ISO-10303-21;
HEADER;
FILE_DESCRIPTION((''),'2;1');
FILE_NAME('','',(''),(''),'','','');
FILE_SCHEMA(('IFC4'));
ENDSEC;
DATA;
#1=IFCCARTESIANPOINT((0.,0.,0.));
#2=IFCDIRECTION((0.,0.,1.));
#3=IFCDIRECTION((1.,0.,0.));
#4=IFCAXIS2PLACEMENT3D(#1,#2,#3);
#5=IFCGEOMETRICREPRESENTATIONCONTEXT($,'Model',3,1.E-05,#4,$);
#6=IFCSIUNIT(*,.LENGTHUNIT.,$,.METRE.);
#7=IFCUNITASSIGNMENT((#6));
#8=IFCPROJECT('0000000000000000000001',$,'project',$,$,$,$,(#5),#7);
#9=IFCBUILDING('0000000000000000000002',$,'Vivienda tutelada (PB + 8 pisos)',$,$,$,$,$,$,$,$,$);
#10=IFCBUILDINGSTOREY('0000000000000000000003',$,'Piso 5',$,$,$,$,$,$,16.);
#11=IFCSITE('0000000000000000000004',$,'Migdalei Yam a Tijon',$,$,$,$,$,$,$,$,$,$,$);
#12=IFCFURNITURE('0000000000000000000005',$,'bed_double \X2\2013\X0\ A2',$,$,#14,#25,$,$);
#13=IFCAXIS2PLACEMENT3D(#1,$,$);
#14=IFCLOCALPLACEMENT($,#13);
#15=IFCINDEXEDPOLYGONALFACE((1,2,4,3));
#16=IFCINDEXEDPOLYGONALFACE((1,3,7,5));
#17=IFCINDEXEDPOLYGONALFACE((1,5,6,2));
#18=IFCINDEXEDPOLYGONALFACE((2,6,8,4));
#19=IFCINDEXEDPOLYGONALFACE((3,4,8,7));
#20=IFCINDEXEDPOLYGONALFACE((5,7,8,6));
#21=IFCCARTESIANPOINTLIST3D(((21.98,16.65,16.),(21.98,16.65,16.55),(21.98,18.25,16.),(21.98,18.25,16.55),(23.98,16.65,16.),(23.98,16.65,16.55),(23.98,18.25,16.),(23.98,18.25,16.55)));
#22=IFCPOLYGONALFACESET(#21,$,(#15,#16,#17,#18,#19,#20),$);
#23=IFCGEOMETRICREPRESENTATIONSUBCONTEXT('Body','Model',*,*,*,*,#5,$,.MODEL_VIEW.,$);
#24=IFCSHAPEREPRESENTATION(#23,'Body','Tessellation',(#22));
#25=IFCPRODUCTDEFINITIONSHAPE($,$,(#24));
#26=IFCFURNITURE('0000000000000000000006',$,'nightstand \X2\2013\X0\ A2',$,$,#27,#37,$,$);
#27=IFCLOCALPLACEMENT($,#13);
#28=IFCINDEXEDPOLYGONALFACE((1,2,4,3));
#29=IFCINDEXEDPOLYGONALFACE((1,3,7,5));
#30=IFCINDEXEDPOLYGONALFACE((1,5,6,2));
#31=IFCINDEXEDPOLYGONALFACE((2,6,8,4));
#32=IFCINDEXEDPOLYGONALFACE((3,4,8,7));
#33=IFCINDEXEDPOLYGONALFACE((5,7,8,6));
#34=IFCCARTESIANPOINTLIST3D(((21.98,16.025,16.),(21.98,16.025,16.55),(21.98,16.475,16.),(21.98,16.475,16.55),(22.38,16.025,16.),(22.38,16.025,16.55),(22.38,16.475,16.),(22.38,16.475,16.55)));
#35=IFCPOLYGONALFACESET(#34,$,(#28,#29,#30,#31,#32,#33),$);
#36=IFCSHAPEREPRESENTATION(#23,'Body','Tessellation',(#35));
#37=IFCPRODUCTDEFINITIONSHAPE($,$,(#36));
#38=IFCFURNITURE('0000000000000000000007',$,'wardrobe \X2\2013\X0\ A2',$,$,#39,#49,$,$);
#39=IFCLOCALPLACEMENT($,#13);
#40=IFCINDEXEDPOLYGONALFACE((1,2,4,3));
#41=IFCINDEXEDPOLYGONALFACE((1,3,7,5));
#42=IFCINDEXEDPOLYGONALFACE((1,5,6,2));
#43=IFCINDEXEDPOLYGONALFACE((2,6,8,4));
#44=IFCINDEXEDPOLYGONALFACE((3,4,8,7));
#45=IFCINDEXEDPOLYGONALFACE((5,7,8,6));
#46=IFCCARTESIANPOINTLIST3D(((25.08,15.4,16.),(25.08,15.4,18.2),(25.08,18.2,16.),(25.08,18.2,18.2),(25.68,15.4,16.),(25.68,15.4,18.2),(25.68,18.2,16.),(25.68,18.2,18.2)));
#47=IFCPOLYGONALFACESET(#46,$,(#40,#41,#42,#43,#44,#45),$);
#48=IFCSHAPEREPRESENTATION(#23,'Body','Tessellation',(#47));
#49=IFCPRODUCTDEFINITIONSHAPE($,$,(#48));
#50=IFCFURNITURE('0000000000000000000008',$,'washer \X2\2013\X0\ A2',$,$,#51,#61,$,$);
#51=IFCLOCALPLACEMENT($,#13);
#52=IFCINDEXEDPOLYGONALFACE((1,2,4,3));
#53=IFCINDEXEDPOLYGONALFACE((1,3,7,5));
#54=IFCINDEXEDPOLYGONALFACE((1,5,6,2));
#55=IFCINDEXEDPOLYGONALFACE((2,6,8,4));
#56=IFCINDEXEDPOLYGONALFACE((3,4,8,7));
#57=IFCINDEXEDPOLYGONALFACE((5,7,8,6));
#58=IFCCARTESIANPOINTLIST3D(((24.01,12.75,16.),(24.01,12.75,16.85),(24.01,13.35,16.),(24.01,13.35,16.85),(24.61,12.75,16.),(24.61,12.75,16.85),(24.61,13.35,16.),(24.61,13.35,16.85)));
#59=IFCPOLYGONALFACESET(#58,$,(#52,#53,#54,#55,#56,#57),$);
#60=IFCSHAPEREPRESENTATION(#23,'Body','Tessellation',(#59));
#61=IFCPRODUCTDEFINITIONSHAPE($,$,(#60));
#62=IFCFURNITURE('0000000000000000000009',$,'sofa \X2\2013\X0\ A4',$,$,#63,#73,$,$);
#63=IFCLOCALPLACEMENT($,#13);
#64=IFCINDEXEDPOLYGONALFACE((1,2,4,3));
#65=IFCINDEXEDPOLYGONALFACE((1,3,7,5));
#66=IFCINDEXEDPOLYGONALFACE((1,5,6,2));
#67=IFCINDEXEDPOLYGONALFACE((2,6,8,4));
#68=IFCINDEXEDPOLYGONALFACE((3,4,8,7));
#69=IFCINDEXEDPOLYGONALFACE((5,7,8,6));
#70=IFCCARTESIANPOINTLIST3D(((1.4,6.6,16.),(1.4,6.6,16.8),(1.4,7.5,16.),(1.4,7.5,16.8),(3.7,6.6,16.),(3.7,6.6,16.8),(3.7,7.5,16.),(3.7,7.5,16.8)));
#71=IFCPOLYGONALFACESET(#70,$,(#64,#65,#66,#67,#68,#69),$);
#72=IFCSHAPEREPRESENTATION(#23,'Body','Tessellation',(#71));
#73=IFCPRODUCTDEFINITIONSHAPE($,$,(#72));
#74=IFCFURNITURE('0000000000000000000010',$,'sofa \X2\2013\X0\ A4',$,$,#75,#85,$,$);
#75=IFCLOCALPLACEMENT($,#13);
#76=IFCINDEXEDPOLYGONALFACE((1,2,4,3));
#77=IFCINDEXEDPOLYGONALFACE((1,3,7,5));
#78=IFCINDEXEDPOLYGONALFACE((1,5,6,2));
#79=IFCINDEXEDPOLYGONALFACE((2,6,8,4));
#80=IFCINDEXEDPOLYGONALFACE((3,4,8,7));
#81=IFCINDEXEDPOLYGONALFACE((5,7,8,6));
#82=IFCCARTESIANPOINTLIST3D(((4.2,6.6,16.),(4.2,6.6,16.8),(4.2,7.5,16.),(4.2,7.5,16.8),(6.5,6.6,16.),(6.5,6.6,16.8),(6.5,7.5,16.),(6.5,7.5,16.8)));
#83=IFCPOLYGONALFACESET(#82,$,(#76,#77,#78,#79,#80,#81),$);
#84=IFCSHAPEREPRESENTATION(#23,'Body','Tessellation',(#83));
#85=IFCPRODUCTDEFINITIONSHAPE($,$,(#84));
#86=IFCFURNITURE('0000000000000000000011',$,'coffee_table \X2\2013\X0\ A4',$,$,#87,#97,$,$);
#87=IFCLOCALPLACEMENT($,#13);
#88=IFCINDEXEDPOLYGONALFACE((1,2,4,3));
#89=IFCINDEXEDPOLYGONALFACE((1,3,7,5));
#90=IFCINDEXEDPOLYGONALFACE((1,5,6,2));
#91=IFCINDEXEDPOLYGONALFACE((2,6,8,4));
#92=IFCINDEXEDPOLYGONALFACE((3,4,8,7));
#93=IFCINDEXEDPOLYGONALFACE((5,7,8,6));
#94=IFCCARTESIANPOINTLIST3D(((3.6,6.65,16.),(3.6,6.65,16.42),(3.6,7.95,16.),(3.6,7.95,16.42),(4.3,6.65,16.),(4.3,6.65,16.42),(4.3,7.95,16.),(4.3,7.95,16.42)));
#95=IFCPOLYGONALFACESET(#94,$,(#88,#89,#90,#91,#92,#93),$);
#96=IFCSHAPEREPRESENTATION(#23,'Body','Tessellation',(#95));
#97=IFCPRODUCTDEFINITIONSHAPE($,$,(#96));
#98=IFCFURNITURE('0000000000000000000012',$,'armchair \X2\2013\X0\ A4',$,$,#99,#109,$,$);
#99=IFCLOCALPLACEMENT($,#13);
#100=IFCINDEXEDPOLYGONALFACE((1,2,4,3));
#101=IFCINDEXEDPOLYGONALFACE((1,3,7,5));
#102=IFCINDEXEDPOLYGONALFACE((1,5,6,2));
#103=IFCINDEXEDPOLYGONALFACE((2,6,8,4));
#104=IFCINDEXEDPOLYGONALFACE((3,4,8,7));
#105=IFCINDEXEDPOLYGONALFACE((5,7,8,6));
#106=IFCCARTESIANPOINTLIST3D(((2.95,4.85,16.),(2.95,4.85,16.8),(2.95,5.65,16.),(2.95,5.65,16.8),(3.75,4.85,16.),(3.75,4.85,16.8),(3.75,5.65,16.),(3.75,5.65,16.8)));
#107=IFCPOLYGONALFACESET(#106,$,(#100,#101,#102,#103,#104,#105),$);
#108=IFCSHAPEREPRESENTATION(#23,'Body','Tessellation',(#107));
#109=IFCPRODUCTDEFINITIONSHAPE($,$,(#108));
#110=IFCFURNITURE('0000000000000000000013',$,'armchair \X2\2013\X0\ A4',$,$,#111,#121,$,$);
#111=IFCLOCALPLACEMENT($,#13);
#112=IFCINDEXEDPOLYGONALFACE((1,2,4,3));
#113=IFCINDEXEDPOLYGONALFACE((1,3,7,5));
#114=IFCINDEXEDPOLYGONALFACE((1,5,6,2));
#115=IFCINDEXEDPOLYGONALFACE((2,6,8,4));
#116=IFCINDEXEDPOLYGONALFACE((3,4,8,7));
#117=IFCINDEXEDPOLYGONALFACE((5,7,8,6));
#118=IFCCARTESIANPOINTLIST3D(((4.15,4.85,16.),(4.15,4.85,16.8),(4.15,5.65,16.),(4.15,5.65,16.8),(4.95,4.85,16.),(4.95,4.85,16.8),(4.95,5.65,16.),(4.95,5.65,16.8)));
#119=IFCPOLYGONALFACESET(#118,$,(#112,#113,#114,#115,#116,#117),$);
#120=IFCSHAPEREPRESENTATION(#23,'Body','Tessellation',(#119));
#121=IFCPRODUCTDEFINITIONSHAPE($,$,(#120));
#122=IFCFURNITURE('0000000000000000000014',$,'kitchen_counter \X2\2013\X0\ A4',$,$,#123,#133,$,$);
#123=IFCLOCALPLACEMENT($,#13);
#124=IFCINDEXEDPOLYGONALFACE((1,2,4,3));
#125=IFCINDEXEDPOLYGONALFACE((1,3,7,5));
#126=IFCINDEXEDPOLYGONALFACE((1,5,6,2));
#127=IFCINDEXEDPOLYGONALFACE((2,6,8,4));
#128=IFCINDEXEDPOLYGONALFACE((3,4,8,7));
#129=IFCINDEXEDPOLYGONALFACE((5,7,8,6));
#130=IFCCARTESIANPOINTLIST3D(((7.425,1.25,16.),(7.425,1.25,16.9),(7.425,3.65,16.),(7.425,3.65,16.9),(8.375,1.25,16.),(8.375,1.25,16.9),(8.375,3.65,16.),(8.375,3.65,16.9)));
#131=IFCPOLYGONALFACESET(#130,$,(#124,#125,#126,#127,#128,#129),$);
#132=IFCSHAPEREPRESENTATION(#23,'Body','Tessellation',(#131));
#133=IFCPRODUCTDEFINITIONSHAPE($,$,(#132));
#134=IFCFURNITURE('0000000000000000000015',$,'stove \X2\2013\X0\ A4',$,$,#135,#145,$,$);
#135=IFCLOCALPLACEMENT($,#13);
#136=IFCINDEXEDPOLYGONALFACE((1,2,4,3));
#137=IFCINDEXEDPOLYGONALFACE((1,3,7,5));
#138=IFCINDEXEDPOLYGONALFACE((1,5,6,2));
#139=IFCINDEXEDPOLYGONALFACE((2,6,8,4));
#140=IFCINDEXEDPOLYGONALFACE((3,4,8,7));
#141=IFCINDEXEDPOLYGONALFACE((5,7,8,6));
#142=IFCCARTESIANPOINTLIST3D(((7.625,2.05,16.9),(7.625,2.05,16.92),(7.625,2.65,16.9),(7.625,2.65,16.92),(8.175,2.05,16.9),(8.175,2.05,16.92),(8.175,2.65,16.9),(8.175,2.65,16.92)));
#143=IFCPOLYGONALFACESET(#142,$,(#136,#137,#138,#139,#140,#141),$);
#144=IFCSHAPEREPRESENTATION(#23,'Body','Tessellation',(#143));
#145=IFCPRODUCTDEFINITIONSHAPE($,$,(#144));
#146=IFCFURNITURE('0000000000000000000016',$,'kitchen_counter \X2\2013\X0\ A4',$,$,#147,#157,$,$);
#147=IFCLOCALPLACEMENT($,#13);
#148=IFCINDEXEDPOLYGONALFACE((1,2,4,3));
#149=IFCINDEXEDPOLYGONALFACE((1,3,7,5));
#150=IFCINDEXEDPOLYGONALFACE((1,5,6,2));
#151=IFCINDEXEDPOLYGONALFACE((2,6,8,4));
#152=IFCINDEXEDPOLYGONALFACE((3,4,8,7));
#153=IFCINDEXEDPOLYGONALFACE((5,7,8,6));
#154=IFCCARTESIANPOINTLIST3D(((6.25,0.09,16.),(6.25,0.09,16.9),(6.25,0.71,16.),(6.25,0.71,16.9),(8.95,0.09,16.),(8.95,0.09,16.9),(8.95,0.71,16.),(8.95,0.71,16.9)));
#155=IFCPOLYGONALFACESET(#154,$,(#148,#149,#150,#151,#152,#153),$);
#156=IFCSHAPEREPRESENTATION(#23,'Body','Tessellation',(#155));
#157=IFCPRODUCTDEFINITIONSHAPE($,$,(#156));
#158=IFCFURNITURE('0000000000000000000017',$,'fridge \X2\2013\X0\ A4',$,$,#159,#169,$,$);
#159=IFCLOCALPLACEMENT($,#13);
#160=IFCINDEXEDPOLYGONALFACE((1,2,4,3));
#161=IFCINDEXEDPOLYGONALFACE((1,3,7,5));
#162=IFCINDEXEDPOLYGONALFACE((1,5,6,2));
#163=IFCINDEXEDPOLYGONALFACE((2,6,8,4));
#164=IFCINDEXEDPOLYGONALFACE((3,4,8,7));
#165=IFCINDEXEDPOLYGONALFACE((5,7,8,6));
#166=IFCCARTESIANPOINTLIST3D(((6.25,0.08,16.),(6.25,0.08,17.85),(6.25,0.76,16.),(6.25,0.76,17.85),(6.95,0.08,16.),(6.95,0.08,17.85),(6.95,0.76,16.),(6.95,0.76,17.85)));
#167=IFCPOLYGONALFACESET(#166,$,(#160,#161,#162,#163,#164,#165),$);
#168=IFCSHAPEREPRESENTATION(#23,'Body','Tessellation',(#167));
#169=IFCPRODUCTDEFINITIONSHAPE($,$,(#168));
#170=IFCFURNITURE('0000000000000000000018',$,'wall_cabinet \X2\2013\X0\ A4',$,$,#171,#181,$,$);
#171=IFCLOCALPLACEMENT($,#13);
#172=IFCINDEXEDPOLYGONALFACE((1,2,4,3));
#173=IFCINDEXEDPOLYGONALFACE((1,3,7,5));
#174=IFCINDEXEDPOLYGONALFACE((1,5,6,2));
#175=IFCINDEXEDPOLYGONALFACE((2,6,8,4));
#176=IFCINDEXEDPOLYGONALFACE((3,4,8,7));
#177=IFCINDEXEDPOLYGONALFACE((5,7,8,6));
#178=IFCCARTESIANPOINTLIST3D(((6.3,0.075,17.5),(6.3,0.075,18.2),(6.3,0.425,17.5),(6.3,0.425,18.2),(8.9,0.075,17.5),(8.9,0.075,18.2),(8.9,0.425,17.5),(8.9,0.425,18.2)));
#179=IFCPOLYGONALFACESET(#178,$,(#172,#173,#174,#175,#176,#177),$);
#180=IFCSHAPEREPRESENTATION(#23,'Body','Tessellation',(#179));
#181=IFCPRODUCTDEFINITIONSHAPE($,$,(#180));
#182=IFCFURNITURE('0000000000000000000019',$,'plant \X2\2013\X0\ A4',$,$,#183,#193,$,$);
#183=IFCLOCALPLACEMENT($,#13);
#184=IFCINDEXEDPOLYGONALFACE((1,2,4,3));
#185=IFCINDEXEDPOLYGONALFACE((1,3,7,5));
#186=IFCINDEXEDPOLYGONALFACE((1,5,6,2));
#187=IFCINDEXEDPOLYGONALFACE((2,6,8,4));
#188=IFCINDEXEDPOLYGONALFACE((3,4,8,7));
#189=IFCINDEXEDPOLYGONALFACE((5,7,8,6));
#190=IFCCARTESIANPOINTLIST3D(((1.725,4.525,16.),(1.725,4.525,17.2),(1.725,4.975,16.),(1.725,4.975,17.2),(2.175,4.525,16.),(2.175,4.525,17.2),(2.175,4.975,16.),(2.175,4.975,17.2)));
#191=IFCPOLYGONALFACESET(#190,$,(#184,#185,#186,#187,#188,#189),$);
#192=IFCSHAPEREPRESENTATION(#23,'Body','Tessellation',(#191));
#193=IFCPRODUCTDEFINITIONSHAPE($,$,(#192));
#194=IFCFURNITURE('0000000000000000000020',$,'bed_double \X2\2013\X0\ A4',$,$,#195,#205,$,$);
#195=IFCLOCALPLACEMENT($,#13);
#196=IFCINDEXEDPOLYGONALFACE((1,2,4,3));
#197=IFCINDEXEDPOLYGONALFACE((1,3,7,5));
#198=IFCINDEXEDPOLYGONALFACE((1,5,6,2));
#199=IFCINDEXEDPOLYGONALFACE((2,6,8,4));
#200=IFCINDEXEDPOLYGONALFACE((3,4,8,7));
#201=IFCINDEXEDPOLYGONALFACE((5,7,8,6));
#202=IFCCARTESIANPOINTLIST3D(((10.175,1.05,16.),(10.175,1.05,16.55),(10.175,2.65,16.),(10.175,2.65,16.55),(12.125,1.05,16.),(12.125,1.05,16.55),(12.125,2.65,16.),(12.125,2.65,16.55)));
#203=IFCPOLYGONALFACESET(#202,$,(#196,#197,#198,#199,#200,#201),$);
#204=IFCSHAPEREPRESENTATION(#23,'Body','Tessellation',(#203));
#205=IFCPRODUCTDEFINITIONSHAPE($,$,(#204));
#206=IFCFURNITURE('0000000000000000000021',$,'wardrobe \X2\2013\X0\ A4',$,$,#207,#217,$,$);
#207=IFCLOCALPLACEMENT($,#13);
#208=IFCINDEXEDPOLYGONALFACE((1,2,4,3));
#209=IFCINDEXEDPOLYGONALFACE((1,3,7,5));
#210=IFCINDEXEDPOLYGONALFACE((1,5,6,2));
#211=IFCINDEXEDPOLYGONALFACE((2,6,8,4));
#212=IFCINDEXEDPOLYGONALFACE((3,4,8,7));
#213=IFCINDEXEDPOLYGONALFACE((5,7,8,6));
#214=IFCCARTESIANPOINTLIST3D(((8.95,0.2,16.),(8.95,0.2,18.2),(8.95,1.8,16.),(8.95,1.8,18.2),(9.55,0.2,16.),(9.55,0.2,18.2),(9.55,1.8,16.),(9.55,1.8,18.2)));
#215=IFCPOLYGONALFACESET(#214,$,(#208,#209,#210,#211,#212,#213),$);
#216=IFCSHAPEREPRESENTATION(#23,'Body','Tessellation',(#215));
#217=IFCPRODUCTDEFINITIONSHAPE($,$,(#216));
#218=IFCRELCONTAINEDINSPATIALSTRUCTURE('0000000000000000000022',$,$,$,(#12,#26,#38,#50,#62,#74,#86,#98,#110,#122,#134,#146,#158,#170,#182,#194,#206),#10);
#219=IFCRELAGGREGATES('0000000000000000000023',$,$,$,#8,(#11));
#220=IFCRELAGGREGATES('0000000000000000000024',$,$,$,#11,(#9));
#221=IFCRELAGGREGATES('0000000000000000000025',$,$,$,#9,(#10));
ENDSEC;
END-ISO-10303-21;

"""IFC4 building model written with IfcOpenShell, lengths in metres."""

from ifc_helpers import new_model, si_unit, frame, origin_with_axes, context, subcontext, project, spatial, line, indexed_curve, outline, extrude, element, save


model = new_model("IFC4")

# Units and contexts
model_context = context("Model", 3, precision=1e-05, world=origin_with_axes())
body_context = subcontext(model_context, "Body", "Model", "MODEL_VIEW")
ifc_project = project(units=[si_unit("LENGTHUNIT", "METRE")], contexts=[model_context])

# Site, building, storey
site = spatial("IfcSite", under=ifc_project, Name="Migdalei Yam a Tijon")
building = spatial("IfcBuilding", under=site, Name="Vivienda tutelada (PB + 8 pisos)")
storey = spatial("IfcBuildingStorey", under=building, Name="Piso 5", Elevation=16.0)

# Furniture
element("IfcFurniture", 1, inside=storey, Name="bed_double – A2", context=body_context, shape_type="SweptSolid", body=[
    extrude(outline(indexed_curve([(0.0, 0.0), (2.0, 0.0), (2.0, 1.6), (0.0, 1.6)], segments=[line(1, 2, 3, 4, 1)])), frame((21.98, 16.65, 16.0), z_axis=(0.0, 0.0, 1.0), x_axis=(1.0, 0.0, 0.0)), (0.0, 0.0, 1.0), 0.55),
])
element("IfcFurniture", 2, inside=storey, Name="nightstand – A2", context=body_context, shape_type="SweptSolid", body=[
    extrude(outline(indexed_curve([(0.0, 0.0), (0.4, 0.0), (0.4, 0.45), (0.0, 0.45)], segments=[line(1, 2, 3, 4, 1)])), frame((21.98, 16.025, 16.0), z_axis=(0.0, 0.0, 1.0), x_axis=(1.0, 0.0, 0.0)), (0.0, 0.0, 1.0), 0.55),
])
element("IfcFurniture", 3, inside=storey, Name="wardrobe – A2", context=body_context, shape_type="SweptSolid", body=[
    extrude(outline(indexed_curve([(0.0, 0.0), (0.6, 0.0), (0.6, 2.8), (0.0, 2.8)], segments=[line(1, 2, 3, 4, 1)])), frame((25.08, 15.4, 16.0), z_axis=(0.0, 0.0, 1.0), x_axis=(1.0, 0.0, 0.0)), (0.0, 0.0, 1.0), 2.2),
])
element("IfcFurniture", 4, inside=storey, Name="washer – A2", context=body_context, shape_type="SweptSolid", body=[
    extrude(outline(indexed_curve([(0.0, 0.0), (0.6, 0.0), (0.6, 0.6), (0.0, 0.6)], segments=[line(1, 2, 3, 4, 1)])), frame((24.01, 12.75, 16.0), z_axis=(0.0, 0.0, 1.0), x_axis=(1.0, 0.0, 0.0)), (0.0, 0.0, 1.0), 0.85),
])
element("IfcFurniture", 5, inside=storey, Name="sofa – A4", context=body_context, shape_type="SweptSolid", body=[
    extrude(outline(indexed_curve([(0.0, 0.0), (2.3, 0.0), (2.3, 0.9), (0.0, 0.9)], segments=[line(1, 2, 3, 4, 1)])), frame((1.4, 6.6, 16.0), z_axis=(0.0, 0.0, 1.0), x_axis=(1.0, 0.0, 0.0)), (0.0, 0.0, 1.0), 0.8),
])
element("IfcFurniture", 6, inside=storey, Name="sofa – A4", context=body_context, shape_type="SweptSolid", body=[
    extrude(outline(indexed_curve([(0.0, 0.0), (2.3, 0.0), (2.3, 0.9), (0.0, 0.9)], segments=[line(1, 2, 3, 4, 1)])), frame((4.2, 6.6, 16.0), z_axis=(0.0, 0.0, 1.0), x_axis=(1.0, 0.0, 0.0)), (0.0, 0.0, 1.0), 0.8),
])
element("IfcFurniture", 7, inside=storey, Name="coffee_table – A4", context=body_context, shape_type="SweptSolid", body=[
    extrude(outline(indexed_curve([(0.0, 0.0), (0.7, 0.0), (0.7, 1.3), (0.0, 1.3)], segments=[line(1, 2, 3, 4, 1)])), frame((3.6, 6.65, 16.0), z_axis=(0.0, 0.0, 1.0), x_axis=(1.0, 0.0, 0.0)), (0.0, 0.0, 1.0), 0.42),
])
element("IfcFurniture", 8, inside=storey, Name="armchair – A4", context=body_context, shape_type="SweptSolid", body=[
    extrude(outline(indexed_curve([(0.0, 0.0), (0.8, 0.0), (0.8, 0.8), (0.0, 0.8)], segments=[line(1, 2, 3, 4, 1)])), frame((2.95, 4.85, 16.0), z_axis=(0.0, 0.0, 1.0), x_axis=(1.0, 0.0, 0.0)), (0.0, 0.0, 1.0), 0.8),
])
element("IfcFurniture", 9, inside=storey, Name="armchair – A4", context=body_context, shape_type="SweptSolid", body=[
    extrude(outline(indexed_curve([(0.0, 0.0), (0.8, 0.0), (0.8, 0.8), (0.0, 0.8)], segments=[line(1, 2, 3, 4, 1)])), frame((4.15, 4.85, 16.0), z_axis=(0.0, 0.0, 1.0), x_axis=(1.0, 0.0, 0.0)), (0.0, 0.0, 1.0), 0.8),
])
element("IfcFurniture", 10, inside=storey, Name="kitchen_counter – A4", context=body_context, shape_type="SweptSolid", body=[
    extrude(outline(indexed_curve([(0.0, 0.0), (0.95, 0.0), (0.95, 2.4), (0.0, 2.4)], segments=[line(1, 2, 3, 4, 1)])), frame((7.425, 1.25, 16.0), z_axis=(0.0, 0.0, 1.0), x_axis=(1.0, 0.0, 0.0)), (0.0, 0.0, 1.0), 0.9),
])
element("IfcFurniture", 11, inside=storey, Name="stove – A4", context=body_context, shape_type="SweptSolid", body=[
    extrude(outline(indexed_curve([(0.0, 0.0), (0.55, 0.0), (0.55, 0.6), (0.0, 0.6)], segments=[line(1, 2, 3, 4, 1)])), frame((7.625, 2.05, 16.9), z_axis=(0.0, 0.0, 1.0), x_axis=(1.0, 0.0, 0.0)), (0.0, 0.0, 1.0), 0.02),
])
element("IfcFurniture", 12, inside=storey, Name="kitchen_counter – A4", context=body_context, shape_type="SweptSolid", body=[
    extrude(outline(indexed_curve([(0.0, 0.0), (2.7, 0.0), (2.7, 0.62), (0.0, 0.62)], segments=[line(1, 2, 3, 4, 1)])), frame((6.25, 0.09, 16.0), z_axis=(0.0, 0.0, 1.0), x_axis=(1.0, 0.0, 0.0)), (0.0, 0.0, 1.0), 0.9),
])
element("IfcFurniture", 13, inside=storey, Name="fridge – A4", context=body_context, shape_type="SweptSolid", body=[
    extrude(outline(indexed_curve([(0.0, 0.0), (0.7, 0.0), (0.7, 0.68), (0.0, 0.68)], segments=[line(1, 2, 3, 4, 1)])), frame((6.25, 0.08, 16.0), z_axis=(0.0, 0.0, 1.0), x_axis=(1.0, 0.0, 0.0)), (0.0, 0.0, 1.0), 1.85),
])
element("IfcFurniture", 14, inside=storey, Name="wall_cabinet – A4", context=body_context, shape_type="SweptSolid", body=[
    extrude(outline(indexed_curve([(0.0, 0.0), (2.6, 0.0), (2.6, 0.35), (0.0, 0.35)], segments=[line(1, 2, 3, 4, 1)])), frame((6.3, 0.075, 17.5), z_axis=(0.0, 0.0, 1.0), x_axis=(1.0, 0.0, 0.0)), (0.0, 0.0, 1.0), 0.7),
])
element("IfcFurniture", 15, inside=storey, Name="plant – A4", context=body_context, shape_type="SweptSolid", body=[
    extrude(outline(indexed_curve([(0.0, 0.0), (0.45, 0.0), (0.45, 0.45), (0.0, 0.45)], segments=[line(1, 2, 3, 4, 1)])), frame((1.725, 4.525, 16.0), z_axis=(0.0, 0.0, 1.0), x_axis=(1.0, 0.0, 0.0)), (0.0, 0.0, 1.0), 1.2),
])
element("IfcFurniture", 16, inside=storey, Name="bed_double – A4", context=body_context, shape_type="SweptSolid", body=[
    extrude(outline(indexed_curve([(0.0, 0.0), (1.95, 0.0), (1.95, 1.6), (0.0, 1.6)], segments=[line(1, 2, 3, 4, 1)])), frame((10.175, 1.05, 16.0), z_axis=(0.0, 0.0, 1.0), x_axis=(1.0, 0.0, 0.0)), (0.0, 0.0, 1.0), 0.55),
])
element("IfcFurniture", 17, inside=storey, Name="wardrobe – A4", context=body_context, shape_type="SweptSolid", body=[
    extrude(outline(indexed_curve([(0.0, 0.0), (0.6, 0.0), (0.6, 1.6), (0.0, 1.6)], segments=[line(1, 2, 3, 4, 1)])), frame((8.95, 0.2, 16.0), z_axis=(0.0, 0.0, 1.0), x_axis=(1.0, 0.0, 0.0)), (0.0, 0.0, 1.0), 2.2),
])

save(model, "model.ifc")
